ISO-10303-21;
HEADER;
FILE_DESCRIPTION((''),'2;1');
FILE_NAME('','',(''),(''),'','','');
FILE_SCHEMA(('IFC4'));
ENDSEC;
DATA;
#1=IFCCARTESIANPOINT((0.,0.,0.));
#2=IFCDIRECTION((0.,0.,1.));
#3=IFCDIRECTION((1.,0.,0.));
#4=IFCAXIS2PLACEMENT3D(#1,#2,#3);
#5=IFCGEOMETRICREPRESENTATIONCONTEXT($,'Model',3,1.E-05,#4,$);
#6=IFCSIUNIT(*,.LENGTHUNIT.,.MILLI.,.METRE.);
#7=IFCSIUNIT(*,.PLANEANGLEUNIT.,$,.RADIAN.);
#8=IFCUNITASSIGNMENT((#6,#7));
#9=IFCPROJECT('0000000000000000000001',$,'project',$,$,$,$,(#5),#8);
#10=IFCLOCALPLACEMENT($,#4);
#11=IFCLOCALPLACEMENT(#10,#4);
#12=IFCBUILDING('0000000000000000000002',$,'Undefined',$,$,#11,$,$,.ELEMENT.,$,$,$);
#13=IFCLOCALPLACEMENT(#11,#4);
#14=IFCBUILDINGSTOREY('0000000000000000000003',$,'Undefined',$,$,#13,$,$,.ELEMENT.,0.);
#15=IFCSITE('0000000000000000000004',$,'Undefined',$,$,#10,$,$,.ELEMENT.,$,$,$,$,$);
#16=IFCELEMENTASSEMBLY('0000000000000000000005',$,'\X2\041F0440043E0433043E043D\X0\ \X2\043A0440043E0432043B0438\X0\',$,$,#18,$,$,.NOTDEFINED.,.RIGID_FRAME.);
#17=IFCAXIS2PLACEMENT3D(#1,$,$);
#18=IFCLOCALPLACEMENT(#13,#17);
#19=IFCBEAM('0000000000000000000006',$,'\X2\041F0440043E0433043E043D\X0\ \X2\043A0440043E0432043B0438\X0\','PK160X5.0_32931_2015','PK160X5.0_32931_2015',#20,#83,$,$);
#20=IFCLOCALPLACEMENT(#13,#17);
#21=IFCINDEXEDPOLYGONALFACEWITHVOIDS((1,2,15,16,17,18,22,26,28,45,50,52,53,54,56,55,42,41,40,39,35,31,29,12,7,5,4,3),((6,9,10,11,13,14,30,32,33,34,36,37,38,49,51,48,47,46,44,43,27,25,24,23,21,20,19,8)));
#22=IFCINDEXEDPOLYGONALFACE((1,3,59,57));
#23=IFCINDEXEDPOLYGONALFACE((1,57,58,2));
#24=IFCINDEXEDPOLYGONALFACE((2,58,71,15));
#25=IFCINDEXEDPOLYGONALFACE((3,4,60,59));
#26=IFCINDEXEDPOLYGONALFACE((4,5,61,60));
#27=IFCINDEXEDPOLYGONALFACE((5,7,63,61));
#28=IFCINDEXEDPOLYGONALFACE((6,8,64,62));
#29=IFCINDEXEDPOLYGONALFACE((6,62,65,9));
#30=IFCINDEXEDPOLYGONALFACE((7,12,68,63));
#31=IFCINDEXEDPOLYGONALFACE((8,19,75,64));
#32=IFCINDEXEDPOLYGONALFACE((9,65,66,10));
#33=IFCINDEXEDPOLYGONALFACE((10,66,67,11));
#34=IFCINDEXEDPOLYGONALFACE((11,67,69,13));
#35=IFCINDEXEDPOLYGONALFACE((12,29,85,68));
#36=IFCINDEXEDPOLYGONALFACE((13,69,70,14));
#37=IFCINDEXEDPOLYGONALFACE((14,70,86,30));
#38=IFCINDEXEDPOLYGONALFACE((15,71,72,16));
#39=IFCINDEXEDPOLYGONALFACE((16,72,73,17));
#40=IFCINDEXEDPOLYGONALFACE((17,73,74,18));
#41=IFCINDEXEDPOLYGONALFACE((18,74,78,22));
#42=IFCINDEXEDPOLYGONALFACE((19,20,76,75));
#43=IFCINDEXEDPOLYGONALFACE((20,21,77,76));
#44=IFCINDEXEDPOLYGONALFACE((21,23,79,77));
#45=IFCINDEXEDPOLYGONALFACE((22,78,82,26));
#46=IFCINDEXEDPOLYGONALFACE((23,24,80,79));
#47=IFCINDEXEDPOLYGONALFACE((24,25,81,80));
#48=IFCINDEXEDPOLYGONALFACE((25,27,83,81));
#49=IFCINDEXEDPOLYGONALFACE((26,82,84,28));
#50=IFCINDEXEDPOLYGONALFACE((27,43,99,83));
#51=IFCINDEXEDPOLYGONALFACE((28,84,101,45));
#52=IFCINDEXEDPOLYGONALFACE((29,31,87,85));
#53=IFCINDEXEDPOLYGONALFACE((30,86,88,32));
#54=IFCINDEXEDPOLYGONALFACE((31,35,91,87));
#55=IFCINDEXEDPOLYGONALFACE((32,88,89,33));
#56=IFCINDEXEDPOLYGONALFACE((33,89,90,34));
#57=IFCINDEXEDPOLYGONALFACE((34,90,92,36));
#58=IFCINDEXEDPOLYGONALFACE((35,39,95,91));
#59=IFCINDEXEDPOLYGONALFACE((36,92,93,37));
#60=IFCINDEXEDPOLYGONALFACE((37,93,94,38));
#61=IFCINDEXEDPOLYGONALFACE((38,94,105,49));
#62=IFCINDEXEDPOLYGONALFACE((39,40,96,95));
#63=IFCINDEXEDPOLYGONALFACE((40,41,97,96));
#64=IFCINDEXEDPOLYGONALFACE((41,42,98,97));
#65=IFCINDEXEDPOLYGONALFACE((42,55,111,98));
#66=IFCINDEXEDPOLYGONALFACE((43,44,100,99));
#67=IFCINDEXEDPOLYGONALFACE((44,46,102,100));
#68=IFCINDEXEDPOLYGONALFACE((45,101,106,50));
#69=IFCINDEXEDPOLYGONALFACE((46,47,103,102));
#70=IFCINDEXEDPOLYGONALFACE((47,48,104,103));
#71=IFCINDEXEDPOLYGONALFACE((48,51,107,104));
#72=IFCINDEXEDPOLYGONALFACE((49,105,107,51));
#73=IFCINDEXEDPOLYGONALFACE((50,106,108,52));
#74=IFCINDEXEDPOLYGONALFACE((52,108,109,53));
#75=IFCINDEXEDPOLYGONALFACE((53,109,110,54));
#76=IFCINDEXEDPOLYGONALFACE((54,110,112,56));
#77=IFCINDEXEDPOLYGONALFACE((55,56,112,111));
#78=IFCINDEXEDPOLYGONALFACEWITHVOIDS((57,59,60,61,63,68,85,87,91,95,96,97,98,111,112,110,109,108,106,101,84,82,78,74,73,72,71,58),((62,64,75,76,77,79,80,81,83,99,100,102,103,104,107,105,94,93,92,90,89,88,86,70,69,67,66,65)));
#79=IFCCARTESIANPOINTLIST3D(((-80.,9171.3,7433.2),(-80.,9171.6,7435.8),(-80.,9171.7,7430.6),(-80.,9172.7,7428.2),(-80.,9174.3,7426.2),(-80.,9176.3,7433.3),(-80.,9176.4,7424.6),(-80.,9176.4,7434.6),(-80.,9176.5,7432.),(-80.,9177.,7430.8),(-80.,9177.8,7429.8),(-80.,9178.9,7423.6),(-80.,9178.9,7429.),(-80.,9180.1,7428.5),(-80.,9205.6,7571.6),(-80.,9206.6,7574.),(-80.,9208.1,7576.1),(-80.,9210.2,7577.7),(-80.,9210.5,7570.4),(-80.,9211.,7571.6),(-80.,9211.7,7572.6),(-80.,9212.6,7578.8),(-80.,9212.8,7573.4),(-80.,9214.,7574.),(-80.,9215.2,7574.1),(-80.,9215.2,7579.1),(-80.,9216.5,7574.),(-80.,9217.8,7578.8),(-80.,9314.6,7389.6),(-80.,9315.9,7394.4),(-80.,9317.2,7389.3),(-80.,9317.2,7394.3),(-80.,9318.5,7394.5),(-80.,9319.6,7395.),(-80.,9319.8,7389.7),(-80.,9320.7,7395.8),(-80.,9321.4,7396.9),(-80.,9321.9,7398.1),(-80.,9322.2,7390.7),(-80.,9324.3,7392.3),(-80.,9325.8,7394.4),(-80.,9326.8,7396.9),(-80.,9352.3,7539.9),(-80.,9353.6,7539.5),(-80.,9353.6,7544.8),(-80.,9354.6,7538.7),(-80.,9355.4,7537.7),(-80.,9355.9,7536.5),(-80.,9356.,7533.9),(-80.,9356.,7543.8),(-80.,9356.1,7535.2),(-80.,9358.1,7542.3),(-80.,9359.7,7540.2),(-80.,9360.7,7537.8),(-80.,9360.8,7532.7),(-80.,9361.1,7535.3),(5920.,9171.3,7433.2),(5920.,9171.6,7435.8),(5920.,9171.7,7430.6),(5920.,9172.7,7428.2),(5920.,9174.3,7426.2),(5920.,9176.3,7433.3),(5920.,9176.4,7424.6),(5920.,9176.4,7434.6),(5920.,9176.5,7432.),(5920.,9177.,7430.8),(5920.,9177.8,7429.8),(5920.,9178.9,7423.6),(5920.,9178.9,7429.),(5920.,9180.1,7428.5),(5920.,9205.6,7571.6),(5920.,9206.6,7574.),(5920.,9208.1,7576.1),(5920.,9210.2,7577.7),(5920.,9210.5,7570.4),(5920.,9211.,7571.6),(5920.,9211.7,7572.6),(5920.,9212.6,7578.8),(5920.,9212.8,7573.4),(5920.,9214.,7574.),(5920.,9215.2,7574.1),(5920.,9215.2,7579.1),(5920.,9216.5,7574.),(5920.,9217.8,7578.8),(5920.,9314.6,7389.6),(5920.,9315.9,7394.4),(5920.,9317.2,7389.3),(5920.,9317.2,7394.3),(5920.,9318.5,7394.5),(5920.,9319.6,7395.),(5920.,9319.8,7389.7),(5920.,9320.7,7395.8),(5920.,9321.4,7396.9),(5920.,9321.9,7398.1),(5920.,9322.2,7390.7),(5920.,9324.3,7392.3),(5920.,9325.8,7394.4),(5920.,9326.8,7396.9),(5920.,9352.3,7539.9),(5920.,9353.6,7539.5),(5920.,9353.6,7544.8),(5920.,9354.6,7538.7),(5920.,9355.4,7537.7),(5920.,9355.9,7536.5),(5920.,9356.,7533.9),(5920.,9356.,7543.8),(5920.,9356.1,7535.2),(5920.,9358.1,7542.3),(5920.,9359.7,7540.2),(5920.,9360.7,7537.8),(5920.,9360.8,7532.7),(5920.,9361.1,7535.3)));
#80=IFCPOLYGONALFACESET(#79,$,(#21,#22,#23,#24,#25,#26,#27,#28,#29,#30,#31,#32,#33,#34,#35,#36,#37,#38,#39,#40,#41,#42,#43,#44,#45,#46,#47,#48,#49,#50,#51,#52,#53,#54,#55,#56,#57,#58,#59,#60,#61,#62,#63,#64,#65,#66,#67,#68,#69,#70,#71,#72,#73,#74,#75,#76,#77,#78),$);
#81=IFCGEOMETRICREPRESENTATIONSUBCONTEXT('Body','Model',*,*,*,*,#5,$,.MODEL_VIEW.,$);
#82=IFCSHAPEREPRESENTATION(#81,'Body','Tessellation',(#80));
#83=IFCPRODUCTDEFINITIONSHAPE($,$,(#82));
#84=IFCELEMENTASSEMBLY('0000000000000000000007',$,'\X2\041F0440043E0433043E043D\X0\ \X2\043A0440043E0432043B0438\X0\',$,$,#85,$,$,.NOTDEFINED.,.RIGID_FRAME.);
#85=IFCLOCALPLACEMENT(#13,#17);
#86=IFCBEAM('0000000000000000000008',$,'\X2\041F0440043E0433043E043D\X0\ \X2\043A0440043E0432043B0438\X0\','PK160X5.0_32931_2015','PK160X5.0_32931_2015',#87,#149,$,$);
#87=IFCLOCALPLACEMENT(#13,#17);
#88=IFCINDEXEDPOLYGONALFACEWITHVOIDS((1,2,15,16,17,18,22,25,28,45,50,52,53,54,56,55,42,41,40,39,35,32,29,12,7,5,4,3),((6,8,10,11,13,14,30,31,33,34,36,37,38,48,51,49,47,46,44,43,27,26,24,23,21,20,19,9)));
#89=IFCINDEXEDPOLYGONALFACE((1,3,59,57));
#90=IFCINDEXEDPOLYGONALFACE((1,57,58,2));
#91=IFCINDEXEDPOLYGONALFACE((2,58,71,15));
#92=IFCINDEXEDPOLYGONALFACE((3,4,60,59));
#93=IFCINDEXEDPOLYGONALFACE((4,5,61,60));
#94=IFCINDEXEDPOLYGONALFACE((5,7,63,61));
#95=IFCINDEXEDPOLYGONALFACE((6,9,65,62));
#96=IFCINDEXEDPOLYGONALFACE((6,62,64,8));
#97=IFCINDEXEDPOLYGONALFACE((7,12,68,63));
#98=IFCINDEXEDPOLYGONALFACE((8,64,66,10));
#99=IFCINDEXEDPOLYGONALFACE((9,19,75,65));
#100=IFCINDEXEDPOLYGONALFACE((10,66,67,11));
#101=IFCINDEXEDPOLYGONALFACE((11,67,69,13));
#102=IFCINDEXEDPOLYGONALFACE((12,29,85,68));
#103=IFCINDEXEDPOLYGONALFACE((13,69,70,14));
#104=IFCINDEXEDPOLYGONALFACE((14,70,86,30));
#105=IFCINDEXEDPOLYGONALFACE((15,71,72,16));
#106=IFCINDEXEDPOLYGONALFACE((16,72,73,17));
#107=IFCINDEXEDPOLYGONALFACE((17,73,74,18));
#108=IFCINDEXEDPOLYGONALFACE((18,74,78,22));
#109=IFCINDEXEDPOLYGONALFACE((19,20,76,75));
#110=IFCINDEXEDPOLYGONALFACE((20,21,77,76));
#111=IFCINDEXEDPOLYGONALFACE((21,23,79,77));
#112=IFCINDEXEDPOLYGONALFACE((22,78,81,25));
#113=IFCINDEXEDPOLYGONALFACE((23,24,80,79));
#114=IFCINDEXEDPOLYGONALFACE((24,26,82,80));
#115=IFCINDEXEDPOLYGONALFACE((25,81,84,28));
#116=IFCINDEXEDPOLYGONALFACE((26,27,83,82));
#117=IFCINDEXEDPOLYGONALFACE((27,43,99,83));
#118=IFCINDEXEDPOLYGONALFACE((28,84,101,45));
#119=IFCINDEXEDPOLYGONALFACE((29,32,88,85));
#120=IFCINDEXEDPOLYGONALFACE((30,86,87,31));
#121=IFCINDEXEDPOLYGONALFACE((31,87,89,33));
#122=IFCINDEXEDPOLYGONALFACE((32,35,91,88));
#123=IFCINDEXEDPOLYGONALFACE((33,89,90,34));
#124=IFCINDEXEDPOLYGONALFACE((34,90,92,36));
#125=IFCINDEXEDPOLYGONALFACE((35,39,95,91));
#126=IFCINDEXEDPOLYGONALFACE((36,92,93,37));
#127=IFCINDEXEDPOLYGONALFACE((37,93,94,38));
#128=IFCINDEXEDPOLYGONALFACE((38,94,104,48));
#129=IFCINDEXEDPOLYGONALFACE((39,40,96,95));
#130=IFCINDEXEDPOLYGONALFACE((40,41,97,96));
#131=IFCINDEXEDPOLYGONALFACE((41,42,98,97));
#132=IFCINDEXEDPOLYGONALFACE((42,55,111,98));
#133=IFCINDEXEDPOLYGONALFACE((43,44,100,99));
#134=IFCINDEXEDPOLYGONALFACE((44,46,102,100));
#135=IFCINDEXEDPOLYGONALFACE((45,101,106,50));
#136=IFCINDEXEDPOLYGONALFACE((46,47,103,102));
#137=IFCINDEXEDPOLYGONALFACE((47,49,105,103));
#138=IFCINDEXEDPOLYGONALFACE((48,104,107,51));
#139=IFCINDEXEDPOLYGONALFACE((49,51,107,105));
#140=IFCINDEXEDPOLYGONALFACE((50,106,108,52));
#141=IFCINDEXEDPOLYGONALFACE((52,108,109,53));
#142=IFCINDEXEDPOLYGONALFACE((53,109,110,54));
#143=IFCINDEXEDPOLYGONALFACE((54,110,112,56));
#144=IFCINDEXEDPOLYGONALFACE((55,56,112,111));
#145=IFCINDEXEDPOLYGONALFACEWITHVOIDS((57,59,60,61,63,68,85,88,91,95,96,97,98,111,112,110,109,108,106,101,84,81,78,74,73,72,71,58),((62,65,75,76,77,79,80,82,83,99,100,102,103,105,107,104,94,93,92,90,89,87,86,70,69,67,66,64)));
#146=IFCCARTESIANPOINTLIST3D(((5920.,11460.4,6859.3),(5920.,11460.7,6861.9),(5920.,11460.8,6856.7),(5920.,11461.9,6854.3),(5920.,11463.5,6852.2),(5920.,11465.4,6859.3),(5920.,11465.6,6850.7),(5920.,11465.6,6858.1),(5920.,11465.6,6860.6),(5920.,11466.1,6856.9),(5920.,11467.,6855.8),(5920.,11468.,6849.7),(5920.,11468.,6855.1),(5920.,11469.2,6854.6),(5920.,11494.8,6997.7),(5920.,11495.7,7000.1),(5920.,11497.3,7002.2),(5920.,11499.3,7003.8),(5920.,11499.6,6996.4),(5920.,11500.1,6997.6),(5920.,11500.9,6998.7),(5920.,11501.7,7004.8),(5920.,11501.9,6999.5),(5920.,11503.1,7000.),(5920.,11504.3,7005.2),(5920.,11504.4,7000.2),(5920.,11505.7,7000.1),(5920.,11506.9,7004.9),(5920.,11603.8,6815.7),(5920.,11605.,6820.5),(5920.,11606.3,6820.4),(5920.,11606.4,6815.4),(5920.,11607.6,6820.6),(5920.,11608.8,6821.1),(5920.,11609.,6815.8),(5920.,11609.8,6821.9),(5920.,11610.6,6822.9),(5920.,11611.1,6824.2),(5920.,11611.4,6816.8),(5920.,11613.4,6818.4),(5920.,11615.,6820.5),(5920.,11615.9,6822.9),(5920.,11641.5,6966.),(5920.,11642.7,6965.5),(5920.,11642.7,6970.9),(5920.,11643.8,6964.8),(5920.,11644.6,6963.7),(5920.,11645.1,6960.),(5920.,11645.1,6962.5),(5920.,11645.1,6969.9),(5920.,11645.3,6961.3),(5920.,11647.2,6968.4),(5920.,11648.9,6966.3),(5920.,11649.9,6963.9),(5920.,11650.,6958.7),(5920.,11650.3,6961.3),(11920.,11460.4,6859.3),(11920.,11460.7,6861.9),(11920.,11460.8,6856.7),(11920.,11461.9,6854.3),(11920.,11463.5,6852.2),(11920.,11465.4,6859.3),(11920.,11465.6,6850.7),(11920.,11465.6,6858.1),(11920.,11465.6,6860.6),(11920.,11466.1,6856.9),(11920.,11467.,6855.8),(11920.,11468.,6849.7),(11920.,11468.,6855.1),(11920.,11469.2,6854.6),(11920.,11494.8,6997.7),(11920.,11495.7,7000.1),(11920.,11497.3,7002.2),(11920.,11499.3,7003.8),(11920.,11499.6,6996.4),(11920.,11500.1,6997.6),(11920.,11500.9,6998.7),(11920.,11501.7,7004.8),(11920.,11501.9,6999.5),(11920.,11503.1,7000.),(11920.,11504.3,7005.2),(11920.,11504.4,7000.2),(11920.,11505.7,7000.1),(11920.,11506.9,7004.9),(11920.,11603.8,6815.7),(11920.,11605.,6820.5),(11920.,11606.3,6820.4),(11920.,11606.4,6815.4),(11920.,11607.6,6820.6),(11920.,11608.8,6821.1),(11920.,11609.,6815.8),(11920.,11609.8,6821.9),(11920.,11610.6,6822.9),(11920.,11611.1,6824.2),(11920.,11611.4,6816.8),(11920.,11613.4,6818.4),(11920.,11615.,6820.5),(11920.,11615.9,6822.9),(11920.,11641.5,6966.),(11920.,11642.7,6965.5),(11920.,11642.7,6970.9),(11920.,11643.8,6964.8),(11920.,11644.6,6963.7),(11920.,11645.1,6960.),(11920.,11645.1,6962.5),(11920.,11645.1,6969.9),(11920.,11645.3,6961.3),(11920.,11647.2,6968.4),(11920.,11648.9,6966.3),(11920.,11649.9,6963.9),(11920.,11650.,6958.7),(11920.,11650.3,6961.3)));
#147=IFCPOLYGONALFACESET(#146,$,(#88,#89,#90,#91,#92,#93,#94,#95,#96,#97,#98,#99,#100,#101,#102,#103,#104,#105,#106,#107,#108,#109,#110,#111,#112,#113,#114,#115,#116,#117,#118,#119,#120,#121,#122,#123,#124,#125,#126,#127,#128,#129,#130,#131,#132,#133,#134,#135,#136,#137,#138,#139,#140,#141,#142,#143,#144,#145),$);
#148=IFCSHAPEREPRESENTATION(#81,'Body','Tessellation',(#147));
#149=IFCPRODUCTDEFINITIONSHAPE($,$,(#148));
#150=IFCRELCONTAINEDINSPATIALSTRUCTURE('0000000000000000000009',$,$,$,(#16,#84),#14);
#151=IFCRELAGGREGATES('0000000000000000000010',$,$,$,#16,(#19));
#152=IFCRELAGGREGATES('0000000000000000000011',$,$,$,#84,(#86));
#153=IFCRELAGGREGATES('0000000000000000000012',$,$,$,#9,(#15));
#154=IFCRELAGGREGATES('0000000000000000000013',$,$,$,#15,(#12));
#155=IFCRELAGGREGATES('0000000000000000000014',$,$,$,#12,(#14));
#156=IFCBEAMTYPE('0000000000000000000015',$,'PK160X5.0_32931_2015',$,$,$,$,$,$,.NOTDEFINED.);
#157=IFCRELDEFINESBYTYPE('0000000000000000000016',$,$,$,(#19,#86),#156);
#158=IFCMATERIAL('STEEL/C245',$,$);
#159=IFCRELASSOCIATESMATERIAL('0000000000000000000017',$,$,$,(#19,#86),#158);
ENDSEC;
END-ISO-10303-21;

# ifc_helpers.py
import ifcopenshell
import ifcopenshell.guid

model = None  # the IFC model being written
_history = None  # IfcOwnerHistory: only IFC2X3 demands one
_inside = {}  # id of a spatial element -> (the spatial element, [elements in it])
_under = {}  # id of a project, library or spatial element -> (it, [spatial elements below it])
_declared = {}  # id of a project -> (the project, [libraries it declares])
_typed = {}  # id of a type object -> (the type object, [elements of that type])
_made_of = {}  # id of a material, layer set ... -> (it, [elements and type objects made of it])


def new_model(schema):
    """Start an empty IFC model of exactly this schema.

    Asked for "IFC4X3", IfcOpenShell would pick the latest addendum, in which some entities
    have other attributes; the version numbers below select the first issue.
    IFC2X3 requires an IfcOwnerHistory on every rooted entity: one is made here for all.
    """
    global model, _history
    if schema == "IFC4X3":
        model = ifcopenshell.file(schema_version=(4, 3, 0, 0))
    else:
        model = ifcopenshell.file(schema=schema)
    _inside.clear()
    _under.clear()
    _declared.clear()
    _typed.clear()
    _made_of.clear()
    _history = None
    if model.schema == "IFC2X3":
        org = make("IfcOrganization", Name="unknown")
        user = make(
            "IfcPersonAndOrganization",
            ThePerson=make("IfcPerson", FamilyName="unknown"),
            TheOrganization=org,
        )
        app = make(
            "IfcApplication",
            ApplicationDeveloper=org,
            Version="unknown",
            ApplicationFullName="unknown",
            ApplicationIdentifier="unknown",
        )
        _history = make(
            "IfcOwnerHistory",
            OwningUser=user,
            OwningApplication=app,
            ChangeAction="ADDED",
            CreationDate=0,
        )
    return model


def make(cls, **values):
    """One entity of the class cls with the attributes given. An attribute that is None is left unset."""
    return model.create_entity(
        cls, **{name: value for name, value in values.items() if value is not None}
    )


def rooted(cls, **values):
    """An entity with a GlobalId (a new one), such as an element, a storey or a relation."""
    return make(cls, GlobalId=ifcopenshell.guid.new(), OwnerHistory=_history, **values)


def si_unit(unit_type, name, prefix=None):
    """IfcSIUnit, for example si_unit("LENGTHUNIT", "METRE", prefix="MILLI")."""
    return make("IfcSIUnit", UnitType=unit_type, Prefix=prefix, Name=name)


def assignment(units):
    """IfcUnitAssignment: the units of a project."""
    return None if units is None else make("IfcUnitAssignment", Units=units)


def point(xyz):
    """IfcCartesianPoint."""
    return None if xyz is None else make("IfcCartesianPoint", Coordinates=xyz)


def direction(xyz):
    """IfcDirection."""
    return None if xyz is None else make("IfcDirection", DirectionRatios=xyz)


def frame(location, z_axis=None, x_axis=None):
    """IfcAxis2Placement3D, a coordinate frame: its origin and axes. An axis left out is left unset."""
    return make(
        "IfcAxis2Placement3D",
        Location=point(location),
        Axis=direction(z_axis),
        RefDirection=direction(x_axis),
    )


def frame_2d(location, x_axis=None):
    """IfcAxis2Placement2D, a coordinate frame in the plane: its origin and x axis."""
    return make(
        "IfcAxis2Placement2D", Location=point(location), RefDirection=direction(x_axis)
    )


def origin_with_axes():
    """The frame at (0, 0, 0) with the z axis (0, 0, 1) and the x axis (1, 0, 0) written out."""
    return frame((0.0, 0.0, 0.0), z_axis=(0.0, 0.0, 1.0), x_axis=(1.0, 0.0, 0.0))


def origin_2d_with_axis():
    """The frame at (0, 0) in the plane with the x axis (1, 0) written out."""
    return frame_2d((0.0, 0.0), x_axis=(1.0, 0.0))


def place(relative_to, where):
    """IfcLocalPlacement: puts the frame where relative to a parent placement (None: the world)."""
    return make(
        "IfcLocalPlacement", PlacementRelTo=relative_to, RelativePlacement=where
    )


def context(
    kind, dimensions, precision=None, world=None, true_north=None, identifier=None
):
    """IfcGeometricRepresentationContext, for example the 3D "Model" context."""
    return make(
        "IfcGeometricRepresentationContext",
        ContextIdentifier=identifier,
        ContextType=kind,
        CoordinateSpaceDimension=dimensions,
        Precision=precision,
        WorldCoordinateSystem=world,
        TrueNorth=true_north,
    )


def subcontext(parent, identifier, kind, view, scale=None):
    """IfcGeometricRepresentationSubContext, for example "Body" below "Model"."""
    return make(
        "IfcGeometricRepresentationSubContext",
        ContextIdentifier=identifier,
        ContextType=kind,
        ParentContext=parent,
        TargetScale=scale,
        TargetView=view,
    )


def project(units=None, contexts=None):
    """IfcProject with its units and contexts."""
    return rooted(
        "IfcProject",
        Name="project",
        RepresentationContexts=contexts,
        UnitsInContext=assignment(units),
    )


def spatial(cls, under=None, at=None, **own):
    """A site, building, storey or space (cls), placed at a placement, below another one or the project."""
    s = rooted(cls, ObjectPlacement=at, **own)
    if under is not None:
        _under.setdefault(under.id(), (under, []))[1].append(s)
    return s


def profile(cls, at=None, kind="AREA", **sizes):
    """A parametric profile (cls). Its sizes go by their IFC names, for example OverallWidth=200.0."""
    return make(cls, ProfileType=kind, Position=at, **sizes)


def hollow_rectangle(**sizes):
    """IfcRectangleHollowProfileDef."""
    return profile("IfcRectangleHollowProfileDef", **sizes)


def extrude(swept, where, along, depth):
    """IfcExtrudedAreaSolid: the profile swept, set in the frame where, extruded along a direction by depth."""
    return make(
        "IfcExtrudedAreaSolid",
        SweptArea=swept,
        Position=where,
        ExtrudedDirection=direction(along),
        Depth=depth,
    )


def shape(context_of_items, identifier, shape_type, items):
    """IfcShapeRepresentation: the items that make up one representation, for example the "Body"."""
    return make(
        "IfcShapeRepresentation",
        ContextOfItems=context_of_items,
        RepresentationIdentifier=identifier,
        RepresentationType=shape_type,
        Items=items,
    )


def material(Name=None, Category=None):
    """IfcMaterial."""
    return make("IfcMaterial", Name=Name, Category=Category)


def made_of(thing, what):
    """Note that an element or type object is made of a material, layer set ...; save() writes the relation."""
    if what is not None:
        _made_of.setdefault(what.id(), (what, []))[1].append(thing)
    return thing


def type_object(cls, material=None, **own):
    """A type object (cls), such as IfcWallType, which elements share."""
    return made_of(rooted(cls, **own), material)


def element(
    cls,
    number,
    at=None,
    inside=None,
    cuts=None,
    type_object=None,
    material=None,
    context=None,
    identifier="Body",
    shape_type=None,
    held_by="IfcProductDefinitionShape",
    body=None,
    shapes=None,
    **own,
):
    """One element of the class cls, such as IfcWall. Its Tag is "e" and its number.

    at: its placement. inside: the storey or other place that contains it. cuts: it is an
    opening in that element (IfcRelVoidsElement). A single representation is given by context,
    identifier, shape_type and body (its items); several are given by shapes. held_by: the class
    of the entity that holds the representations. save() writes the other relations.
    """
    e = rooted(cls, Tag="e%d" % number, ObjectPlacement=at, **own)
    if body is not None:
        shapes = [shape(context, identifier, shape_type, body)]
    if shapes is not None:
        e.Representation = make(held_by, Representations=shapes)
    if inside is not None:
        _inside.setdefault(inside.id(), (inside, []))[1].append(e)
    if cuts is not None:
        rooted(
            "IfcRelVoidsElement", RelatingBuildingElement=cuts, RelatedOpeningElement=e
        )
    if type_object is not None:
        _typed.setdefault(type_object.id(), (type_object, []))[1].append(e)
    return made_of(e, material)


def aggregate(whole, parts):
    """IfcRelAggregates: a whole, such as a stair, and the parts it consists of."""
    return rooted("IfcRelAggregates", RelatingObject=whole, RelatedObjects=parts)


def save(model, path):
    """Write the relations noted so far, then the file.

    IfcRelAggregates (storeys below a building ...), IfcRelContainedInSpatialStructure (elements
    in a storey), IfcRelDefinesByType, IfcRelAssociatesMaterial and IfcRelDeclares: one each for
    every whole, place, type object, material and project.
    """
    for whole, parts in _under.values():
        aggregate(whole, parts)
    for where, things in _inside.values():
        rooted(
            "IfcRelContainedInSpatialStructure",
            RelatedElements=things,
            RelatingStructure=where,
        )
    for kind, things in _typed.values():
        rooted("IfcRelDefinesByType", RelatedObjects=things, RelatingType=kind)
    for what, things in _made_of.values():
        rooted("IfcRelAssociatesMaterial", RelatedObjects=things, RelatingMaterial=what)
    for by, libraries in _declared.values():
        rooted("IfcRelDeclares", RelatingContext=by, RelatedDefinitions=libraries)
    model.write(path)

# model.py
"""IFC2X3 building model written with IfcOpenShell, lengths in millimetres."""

from ifc_helpers import new_model, si_unit, frame, origin_with_axes, origin_2d_with_axis, place, context, subcontext, project, spatial, hollow_rectangle, extrude, material, type_object, element, aggregate, save


model = new_model("IFC2X3")

# Units and contexts
model_context = context("Model", 3, precision=1e-05, world=origin_with_axes())
body_context = subcontext(model_context, "Body", "Model", "MODEL_VIEW")
ifc_project = project(units=[si_unit("LENGTHUNIT", "METRE", prefix="MILLI"), si_unit("PLANEANGLEUNIT", "RADIAN")], contexts=[model_context])

# Site, building, storey
site_placement = place(None, origin_with_axes())
site = spatial("IfcSite", under=ifc_project, at=site_placement, Name="Undefined", CompositionType="ELEMENT")
building_placement = place(site_placement, origin_with_axes())
building = spatial("IfcBuilding", under=site, at=building_placement, Name="Undefined", CompositionType="ELEMENT")
storey_placement = place(building_placement, origin_with_axes())
storey = spatial("IfcBuildingStorey", under=building, at=storey_placement, Name="Undefined", CompositionType="ELEMENT", Elevation=0.0)

# Shared definitions
ifc_material = material(Name="STEEL/C245")

# Element assemblies, beams
beam_type_1 = type_object("IfcBeamType", Name="PK160X5.0_32931_2015", PredefinedType="NOTDEFINED")
assembly_1_placement = place(storey_placement, origin_with_axes())
assembly_1 = element("IfcElementAssembly", 1, at=assembly_1_placement, inside=storey, Name="Прогон кровли", AssemblyPlace="NOTDEFINED", PredefinedType="RIGID_FRAME")
beam_1_placement = place(assembly_1_placement, frame((-80.0, 9266.2, 7484.2), z_axis=(0.0, 0.243188, 0.969979), x_axis=(1.0, 0.0, 0.0)))
beam_1 = element("IfcBeam", 2, at=beam_1_placement, type_object=beam_type_1, material=ifc_material, Name="Прогон кровли", Description="PK160X5.0_32931_2015", ObjectType="PK160X5.0_32931_2015", context=body_context, shape_type="SweptSolid", body=[
    extrude(hollow_rectangle(XDim=160.0, YDim=160.0, WallThickness=5.0, InnerFilletRadius=5.0, OuterFilletRadius=10.0, at=origin_2d_with_axis()), frame((6000.0, 0.0, 0.0), z_axis=(-1.0, 0.0, 0.0), x_axis=(0.0, -1.0, 0.0)), (0.0, 0.0, 1.0), 6000.0),
])
aggregate(assembly_1, [beam_1])
assembly_2_placement = place(storey_placement, origin_with_axes())
assembly_2 = element("IfcElementAssembly", 3, at=assembly_2_placement, inside=storey, Name="Прогон кровли", AssemblyPlace="NOTDEFINED", PredefinedType="RIGID_FRAME")
beam_2_placement = place(assembly_2_placement, frame((5920.0, 11555.4, 6910.3), z_axis=(0.0, 0.243188, 0.969979), x_axis=(1.0, 0.0, 0.0)))
beam_2 = element("IfcBeam", 4, at=beam_2_placement, type_object=beam_type_1, material=ifc_material, Name="Прогон кровли", Description="PK160X5.0_32931_2015", ObjectType="PK160X5.0_32931_2015", context=body_context, shape_type="SweptSolid", body=[
    extrude(hollow_rectangle(XDim=160.0, YDim=160.0, WallThickness=5.0, InnerFilletRadius=5.0, OuterFilletRadius=10.0, at=origin_2d_with_axis()), frame((6000.0, 0.0, 0.0), z_axis=(-1.0, 0.0, 0.0), x_axis=(0.0, -1.0, 0.0)), (0.0, 0.0, 1.0), 6000.0),
])
aggregate(assembly_2, [beam_2])

save(model, "model.ifc")
